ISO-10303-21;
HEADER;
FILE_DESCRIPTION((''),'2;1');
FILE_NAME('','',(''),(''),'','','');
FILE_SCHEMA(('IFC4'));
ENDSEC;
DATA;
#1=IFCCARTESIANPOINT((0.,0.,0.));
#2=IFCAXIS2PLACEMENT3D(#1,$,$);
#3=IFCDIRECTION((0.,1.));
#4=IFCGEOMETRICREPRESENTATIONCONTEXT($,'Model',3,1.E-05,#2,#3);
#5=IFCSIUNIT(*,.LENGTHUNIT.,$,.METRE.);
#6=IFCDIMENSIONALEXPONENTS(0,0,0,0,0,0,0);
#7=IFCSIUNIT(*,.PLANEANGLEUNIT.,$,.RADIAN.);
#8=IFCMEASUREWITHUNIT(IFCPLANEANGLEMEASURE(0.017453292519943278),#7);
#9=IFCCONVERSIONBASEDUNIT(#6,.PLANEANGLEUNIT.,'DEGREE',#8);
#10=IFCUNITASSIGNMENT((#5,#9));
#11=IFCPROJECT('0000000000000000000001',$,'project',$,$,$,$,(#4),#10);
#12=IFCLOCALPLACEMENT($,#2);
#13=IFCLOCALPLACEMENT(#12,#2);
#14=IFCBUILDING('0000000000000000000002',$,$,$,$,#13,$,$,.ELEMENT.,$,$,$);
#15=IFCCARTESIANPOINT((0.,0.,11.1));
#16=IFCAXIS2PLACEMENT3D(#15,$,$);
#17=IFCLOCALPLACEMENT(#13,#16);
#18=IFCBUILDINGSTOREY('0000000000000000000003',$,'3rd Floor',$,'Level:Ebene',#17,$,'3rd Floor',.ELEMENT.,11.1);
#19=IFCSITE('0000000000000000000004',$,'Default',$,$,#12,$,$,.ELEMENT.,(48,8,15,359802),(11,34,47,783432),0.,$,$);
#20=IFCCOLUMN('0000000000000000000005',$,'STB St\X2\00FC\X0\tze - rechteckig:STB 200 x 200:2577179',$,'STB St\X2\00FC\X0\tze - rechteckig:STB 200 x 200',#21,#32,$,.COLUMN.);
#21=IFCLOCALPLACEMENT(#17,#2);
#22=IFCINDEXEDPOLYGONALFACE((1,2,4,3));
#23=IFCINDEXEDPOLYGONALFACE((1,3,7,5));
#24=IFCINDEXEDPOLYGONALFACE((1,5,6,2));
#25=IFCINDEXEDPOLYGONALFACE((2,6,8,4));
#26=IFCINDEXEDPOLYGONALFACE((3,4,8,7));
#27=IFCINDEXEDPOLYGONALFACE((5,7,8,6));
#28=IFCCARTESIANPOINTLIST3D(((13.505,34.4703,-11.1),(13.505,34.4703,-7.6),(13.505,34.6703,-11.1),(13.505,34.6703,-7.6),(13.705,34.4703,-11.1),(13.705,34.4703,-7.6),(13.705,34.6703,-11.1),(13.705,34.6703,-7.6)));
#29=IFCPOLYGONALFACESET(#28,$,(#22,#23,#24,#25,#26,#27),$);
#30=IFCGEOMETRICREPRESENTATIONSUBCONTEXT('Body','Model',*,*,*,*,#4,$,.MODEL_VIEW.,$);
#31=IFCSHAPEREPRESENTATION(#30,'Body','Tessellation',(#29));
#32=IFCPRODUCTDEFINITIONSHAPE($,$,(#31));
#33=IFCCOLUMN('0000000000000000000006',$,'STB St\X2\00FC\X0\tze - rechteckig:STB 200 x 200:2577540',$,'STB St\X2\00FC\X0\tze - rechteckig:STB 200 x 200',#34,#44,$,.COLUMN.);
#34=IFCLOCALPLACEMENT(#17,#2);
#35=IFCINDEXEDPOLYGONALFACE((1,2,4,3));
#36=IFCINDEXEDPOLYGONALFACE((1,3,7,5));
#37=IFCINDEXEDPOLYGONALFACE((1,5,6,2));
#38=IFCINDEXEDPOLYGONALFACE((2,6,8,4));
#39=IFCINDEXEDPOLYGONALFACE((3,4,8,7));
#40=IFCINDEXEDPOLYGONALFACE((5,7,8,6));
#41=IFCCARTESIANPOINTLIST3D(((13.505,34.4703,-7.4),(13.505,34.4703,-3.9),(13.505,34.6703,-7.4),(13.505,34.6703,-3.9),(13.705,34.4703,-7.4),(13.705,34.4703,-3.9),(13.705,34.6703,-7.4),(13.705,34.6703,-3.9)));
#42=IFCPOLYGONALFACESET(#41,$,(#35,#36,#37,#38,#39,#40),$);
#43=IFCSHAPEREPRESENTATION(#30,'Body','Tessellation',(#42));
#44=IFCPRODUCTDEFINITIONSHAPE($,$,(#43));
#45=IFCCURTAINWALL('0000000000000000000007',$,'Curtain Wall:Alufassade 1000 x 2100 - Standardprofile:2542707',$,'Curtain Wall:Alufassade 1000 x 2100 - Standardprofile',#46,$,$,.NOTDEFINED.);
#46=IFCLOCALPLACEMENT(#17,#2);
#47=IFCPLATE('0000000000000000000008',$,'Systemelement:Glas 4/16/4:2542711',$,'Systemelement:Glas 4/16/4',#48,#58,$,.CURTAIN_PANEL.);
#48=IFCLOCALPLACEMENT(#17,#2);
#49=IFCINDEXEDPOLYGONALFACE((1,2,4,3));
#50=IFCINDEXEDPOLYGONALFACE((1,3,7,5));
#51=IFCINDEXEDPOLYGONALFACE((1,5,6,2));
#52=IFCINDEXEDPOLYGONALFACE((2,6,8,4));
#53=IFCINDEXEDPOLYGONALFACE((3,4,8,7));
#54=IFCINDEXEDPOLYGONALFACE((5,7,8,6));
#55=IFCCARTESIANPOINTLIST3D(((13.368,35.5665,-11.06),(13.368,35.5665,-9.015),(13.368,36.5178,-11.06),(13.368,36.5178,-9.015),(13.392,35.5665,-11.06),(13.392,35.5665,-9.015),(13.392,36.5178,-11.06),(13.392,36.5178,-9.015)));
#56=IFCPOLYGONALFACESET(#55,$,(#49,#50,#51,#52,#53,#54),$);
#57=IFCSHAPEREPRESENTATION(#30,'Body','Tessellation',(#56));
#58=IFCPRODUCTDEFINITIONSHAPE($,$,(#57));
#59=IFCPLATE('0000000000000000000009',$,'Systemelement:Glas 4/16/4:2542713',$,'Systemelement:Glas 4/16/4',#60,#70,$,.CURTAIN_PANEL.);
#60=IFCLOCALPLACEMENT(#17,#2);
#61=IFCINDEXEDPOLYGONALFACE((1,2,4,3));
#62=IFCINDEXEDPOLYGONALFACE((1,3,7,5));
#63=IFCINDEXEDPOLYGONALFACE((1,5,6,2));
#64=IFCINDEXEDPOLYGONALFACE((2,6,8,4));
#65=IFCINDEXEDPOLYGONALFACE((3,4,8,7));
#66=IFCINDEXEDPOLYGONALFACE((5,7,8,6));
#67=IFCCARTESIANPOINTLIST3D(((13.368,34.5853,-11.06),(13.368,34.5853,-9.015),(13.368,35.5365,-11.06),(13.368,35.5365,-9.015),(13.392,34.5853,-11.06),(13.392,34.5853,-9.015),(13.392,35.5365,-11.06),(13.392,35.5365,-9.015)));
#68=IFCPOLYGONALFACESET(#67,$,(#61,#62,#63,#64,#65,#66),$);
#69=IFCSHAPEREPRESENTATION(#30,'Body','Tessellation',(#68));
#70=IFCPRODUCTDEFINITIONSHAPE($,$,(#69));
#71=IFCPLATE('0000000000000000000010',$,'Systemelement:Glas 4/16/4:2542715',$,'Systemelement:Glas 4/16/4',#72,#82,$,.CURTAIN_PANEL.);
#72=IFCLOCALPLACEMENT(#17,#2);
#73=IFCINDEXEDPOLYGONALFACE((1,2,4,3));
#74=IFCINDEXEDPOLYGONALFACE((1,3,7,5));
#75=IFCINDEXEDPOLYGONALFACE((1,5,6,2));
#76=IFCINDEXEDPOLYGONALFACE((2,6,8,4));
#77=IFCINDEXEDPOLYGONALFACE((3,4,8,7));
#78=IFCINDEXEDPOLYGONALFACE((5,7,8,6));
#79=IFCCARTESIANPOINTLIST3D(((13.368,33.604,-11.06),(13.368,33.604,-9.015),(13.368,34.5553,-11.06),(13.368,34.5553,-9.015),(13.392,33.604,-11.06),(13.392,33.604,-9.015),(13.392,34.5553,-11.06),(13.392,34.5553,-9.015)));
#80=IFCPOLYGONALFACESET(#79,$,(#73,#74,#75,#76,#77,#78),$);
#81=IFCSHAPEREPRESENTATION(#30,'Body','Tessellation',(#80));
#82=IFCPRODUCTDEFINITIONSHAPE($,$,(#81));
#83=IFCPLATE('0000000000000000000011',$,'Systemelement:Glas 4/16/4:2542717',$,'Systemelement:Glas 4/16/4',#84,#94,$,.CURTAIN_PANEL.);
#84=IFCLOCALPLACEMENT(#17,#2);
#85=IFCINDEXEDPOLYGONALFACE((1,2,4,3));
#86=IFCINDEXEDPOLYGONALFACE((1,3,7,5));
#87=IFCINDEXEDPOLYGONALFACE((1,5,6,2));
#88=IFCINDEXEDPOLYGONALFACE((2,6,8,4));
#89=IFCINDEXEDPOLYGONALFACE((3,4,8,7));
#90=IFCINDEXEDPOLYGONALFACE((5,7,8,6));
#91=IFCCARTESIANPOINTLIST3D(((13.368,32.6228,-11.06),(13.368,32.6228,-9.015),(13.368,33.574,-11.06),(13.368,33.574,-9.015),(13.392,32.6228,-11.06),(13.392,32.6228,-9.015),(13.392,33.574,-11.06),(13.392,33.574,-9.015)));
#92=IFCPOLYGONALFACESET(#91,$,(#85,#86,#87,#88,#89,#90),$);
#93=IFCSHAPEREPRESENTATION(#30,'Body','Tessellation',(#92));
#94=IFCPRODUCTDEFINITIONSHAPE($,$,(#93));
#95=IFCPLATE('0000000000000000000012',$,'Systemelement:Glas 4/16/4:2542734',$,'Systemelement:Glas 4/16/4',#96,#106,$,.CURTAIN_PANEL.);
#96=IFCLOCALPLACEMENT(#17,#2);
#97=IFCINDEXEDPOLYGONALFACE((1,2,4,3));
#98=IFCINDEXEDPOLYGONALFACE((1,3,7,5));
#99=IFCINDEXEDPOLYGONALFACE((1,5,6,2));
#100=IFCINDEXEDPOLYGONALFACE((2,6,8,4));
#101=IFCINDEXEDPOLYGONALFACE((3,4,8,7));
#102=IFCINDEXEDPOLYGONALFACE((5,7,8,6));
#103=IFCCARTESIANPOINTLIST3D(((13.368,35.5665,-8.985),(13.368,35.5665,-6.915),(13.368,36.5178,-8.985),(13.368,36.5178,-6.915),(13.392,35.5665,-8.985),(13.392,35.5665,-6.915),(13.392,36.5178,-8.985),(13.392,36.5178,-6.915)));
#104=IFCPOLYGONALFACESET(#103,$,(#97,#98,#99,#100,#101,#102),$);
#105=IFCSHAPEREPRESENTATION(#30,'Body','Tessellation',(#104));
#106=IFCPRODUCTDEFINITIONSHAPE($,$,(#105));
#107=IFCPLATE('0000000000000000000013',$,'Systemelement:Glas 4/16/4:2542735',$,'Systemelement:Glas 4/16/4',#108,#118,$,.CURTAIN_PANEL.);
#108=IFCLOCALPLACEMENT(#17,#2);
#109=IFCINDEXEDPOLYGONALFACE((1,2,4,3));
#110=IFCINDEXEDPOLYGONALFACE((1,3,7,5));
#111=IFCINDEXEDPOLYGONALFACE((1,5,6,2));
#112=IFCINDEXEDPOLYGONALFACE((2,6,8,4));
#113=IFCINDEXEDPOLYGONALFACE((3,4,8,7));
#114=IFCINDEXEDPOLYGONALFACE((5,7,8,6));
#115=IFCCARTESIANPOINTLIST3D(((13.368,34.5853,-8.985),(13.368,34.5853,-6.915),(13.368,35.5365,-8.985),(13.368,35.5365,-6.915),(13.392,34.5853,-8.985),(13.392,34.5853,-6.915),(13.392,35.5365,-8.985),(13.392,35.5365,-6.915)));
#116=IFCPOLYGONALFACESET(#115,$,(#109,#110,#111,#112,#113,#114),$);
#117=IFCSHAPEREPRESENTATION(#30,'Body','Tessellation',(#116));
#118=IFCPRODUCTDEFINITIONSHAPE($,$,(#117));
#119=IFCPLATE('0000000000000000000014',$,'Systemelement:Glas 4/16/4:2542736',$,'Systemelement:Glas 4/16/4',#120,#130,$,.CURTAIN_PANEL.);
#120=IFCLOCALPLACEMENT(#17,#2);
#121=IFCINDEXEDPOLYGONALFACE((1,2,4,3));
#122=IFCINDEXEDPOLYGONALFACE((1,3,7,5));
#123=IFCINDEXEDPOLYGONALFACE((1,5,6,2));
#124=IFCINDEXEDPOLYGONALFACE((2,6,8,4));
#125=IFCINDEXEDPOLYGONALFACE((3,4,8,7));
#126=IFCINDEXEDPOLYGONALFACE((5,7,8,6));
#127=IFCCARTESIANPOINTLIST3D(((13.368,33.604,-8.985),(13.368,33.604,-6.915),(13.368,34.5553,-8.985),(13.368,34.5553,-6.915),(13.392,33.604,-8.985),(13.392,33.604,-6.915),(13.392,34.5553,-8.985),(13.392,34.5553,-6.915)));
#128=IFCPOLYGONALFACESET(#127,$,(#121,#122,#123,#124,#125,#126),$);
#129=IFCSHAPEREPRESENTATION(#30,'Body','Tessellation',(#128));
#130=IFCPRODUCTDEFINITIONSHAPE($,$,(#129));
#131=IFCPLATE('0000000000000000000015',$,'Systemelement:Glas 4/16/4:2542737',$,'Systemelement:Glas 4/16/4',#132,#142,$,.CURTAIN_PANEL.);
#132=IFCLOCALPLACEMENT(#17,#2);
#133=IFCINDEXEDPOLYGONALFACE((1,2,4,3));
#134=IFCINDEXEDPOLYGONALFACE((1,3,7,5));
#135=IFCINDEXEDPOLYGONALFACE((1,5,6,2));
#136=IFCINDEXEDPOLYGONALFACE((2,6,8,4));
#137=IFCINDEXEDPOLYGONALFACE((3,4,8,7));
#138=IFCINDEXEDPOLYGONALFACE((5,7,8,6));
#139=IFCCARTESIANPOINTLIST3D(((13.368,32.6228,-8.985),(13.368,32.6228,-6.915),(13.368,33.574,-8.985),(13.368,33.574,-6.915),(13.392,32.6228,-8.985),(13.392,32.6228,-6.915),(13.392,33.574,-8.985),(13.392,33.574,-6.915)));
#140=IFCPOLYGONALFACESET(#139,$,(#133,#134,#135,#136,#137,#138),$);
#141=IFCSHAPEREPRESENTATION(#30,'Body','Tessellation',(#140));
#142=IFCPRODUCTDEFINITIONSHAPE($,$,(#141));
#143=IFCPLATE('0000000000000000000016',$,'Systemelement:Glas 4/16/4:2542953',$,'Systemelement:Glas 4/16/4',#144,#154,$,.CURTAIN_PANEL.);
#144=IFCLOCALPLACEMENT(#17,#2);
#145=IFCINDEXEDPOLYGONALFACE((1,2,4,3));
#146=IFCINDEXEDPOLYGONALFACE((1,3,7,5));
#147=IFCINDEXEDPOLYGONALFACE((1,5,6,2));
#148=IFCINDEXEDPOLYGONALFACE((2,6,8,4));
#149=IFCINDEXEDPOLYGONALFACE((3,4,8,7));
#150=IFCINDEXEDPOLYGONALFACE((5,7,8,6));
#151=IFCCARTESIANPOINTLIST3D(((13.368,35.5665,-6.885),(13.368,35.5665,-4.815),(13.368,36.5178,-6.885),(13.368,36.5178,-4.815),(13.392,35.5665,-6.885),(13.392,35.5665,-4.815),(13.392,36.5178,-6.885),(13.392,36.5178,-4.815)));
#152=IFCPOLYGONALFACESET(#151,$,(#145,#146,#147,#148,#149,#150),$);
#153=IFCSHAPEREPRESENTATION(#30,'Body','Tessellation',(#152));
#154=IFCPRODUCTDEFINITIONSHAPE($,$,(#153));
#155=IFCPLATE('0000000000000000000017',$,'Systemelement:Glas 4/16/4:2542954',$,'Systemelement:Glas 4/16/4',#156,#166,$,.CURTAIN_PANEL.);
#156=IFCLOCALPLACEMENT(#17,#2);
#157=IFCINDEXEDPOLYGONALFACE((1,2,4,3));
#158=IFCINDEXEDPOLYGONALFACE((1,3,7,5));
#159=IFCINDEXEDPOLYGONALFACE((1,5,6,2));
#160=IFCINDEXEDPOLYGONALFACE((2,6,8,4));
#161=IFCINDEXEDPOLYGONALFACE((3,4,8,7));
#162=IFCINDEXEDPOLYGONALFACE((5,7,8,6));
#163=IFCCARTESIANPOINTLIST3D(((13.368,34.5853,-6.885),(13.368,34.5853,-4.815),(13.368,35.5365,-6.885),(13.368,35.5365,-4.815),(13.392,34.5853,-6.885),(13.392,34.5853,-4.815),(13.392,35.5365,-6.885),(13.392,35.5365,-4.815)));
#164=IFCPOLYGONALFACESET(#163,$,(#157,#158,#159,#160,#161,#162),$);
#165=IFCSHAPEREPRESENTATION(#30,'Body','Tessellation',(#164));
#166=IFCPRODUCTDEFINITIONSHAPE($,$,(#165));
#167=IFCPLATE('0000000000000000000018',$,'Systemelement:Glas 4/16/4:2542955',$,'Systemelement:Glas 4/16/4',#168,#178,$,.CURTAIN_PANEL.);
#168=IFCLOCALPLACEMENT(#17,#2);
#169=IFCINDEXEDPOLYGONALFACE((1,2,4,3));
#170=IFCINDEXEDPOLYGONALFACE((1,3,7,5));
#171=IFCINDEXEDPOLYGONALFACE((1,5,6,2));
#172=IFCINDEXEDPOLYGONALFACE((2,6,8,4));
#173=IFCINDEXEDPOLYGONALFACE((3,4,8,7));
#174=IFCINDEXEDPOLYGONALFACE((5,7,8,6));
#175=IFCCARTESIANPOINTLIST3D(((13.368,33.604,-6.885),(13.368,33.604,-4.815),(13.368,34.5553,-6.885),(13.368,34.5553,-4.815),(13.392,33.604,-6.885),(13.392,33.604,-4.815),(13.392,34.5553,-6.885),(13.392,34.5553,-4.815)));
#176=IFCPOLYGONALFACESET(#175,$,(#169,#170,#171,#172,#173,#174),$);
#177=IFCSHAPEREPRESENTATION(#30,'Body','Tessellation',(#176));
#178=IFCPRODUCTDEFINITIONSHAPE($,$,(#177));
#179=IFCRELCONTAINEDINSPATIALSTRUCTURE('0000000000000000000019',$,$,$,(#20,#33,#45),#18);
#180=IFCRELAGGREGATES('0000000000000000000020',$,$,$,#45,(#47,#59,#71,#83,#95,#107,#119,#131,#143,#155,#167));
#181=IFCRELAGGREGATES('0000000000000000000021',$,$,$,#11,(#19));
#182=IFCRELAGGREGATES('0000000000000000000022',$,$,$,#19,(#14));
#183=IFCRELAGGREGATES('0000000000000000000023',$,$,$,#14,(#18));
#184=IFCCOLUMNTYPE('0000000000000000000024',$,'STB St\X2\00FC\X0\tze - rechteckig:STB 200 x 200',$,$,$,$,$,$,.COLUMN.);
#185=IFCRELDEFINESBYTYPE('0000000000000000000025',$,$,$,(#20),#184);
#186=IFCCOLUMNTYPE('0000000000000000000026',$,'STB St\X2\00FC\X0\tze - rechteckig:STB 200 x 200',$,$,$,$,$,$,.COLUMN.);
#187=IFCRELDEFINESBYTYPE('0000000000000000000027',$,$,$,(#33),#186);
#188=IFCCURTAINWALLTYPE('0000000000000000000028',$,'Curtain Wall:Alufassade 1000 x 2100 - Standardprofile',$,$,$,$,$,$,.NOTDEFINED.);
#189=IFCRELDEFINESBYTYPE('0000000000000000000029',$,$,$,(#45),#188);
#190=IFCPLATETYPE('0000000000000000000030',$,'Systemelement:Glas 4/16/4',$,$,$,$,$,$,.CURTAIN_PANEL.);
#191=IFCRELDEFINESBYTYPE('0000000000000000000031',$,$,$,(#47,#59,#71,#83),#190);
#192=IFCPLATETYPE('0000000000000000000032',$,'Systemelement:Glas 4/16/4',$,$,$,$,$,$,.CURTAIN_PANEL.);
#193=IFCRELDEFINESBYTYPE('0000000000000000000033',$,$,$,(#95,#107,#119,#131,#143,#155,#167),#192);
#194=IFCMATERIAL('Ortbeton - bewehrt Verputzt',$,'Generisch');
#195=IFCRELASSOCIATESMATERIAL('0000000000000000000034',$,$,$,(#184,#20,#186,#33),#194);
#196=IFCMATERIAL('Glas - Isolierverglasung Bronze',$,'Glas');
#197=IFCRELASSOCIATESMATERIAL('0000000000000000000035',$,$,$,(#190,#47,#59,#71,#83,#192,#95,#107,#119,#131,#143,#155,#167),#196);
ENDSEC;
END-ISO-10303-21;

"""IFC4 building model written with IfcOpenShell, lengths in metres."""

from ifc_helpers import new_model, entity, si_unit, converted_unit, direction, frame, origin, place, context, subcontext, project, spatial, indexed_curve, outline, extrude, source, transform, mapped, material, type_object, type_shapes, element, aggregate, save


model = new_model("IFC4")

# Units and contexts
model_context = context("Model", 3, precision=1e-05, world=origin(), true_north=direction((0.0, 1.0)))
body_context = subcontext(model_context, "Body", "Model", "MODEL_VIEW")
ifc_project = project(units=[si_unit("LENGTHUNIT", "METRE"), converted_unit("PLANEANGLEUNIT", "DEGREE", entity("IfcPlaneAngleMeasure", 0.017453292519943278), si_unit("PLANEANGLEUNIT", "RADIAN"), dimensions=[0, 0, 0, 0, 0, 0, 0])], contexts=[model_context])

# Site, building, storey
site_placement = place(None, origin())
site = spatial("IfcSite", under=ifc_project, at=site_placement, Name="Default", CompositionType="ELEMENT", RefLatitude=(48, 8, 15, 359802), RefLongitude=(11, 34, 47, 783432), RefElevation=0.0)
building_placement = place(site_placement, origin())
building = spatial("IfcBuilding", under=site, at=building_placement, CompositionType="ELEMENT")
storey_placement = place(building_placement, frame((0.0, 0.0, 11.1)))
storey = spatial("IfcBuildingStorey", under=building, at=storey_placement, Name="3rd Floor", ObjectType="Level:Ebene", LongName="3rd Floor", CompositionType="ELEMENT", Elevation=11.1)

# Columns
ifc_material_1 = material(Name="Ortbeton - bewehrt Verputzt", Category="Generisch")
column_type_1 = type_object("IfcColumnType", Name="STB Stütze - rechteckig:STB 200 x 200", PredefinedType="COLUMN", material=ifc_material_1)
shared_shape_1 = source(origin(), body_context, "Body", "SweptSolid", [
    extrude(outline(indexed_curve([(-0.1, -0.1), (0.1, -0.1), (0.1, 0.1), (-0.1, 0.1), (-0.1, -0.1)], self_intersect=False)), frame((0.0, 0.0, 0.0), z_axis=(0.0, 0.0, 1.0), x_axis=(-1.0, 0.0, 0.0)), (0.0, 0.0, 1.0), 3.5),
])
type_shapes(column_type_1, [shared_shape_1])
column_1_placement = place(storey_placement, frame((13.605, 34.5703, -11.1)))
element("IfcColumn", 1, at=column_1_placement, inside=storey, type_object=column_type_1, material=ifc_material_1, Name="STB Stütze - rechteckig:STB 200 x 200:2577179", ObjectType="STB Stütze - rechteckig:STB 200 x 200", PredefinedType="COLUMN", context=body_context, shape_type="MappedRepresentation", body=[
    mapped(shared_shape_1, transform((0.0, 0.0, 0.0), scale=1.0)),
])
column_type_2 = type_object("IfcColumnType", Name="STB Stütze - rechteckig:STB 200 x 200", PredefinedType="COLUMN", material=ifc_material_1)
shared_shape_2 = source(origin(), body_context, "Body", "SweptSolid", [
    extrude(outline(indexed_curve([(-0.1, -0.1), (0.1, -0.1), (0.1, 0.1), (-0.1, 0.1), (-0.1, -0.1)], self_intersect=False)), frame((0.0, 0.0, 3.7), z_axis=(0.0, 0.0, 1.0), x_axis=(-1.0, 0.0, 0.0)), (0.0, 0.0, 1.0), 3.5),
])
type_shapes(column_type_2, [shared_shape_2])
column_2_placement = place(storey_placement, frame((13.605, 34.5703, -11.1)))
element("IfcColumn", 2, at=column_2_placement, inside=storey, type_object=column_type_2, material=ifc_material_1, Name="STB Stütze - rechteckig:STB 200 x 200:2577540", ObjectType="STB Stütze - rechteckig:STB 200 x 200", PredefinedType="COLUMN", context=body_context, shape_type="MappedRepresentation", body=[
    mapped(shared_shape_2, transform((0.0, 0.0, 0.0), scale=1.0)),
])

# Curtain wall, plates
curtain_wall_type = type_object("IfcCurtainWallType", Name="Curtain Wall:Alufassade 1000 x 2100 - Standardprofile", PredefinedType="NOTDEFINED")
curtain_wall_placement = place(storey_placement, frame((0.0, 0.0, -11.1)))
curtain_wall = element("IfcCurtainWall", 3, at=curtain_wall_placement, inside=storey, type_object=curtain_wall_type, Name="Curtain Wall:Alufassade 1000 x 2100 - Standardprofile:2542707", ObjectType="Curtain Wall:Alufassade 1000 x 2100 - Standardprofile", PredefinedType="NOTDEFINED")
ifc_material_2 = material(Name="Glas - Isolierverglasung Bronze", Category="Glas")
plate_type_1 = type_object("IfcPlateType", Name="Systemelement:Glas 4/16/4", PredefinedType="CURTAIN_PANEL", material=ifc_material_2)
shared_shape_3 = source(origin(), body_context, "Body", "SweptSolid", [
    extrude(outline(indexed_curve([(-0.012, -0.4756), (0.012, -0.4756), (0.012, 0.4756), (-0.012, 0.4756), (-0.012, -0.4756)], self_intersect=False)), frame((0.0, 0.0, 0.0), z_axis=(0.0, 0.0, 1.0), x_axis=(0.0, 1.0, 0.0)), (0.0, 0.0, 1.0), 2.045),
])
type_shapes(plate_type_1, [shared_shape_3])
plate_1_placement = place(curtain_wall_placement, frame((13.38, 36.0421, 0.04), z_axis=(0.0, 0.0, 1.0), x_axis=(0.0, -1.0, 0.0)))
plate_1 = element("IfcPlate", 4, at=plate_1_placement, type_object=plate_type_1, material=ifc_material_2, Name="Systemelement:Glas 4/16/4:2542711", ObjectType="Systemelement:Glas 4/16/4", PredefinedType="CURTAIN_PANEL", context=body_context, shape_type="MappedRepresentation", body=[
    mapped(shared_shape_3, transform((0.0, 0.0, 0.0), scale=1.0)),
])
plate_2_placement = place(curtain_wall_placement, frame((13.38, 35.0609, 0.04), z_axis=(0.0, 0.0, 1.0), x_axis=(0.0, -1.0, 0.0)))
plate_2 = element("IfcPlate", 5, at=plate_2_placement, type_object=plate_type_1, material=ifc_material_2, Name="Systemelement:Glas 4/16/4:2542713", ObjectType="Systemelement:Glas 4/16/4", PredefinedType="CURTAIN_PANEL", context=body_context, shape_type="MappedRepresentation", body=[
    mapped(shared_shape_3, transform((0.0, 0.0, 0.0), scale=1.0)),
])
plate_3_placement = place(curtain_wall_placement, frame((13.38, 34.0796, 0.04), z_axis=(0.0, 0.0, 1.0), x_axis=(0.0, -1.0, 0.0)))
plate_3 = element("IfcPlate", 6, at=plate_3_placement, type_object=plate_type_1, material=ifc_material_2, Name="Systemelement:Glas 4/16/4:2542715", ObjectType="Systemelement:Glas 4/16/4", PredefinedType="CURTAIN_PANEL", context=body_context, shape_type="MappedRepresentation", body=[
    mapped(shared_shape_3, transform((0.0, 0.0, 0.0), scale=1.0)),
])
plate_4_placement = place(curtain_wall_placement, frame((13.38, 33.0984, 0.04), z_axis=(0.0, 0.0, 1.0), x_axis=(0.0, -1.0, 0.0)))
plate_4 = element("IfcPlate", 7, at=plate_4_placement, type_object=plate_type_1, material=ifc_material_2, Name="Systemelement:Glas 4/16/4:2542717", ObjectType="Systemelement:Glas 4/16/4", PredefinedType="CURTAIN_PANEL", context=body_context, shape_type="MappedRepresentation", body=[
    mapped(shared_shape_3, transform((0.0, 0.0, 0.0), scale=1.0)),
])
plate_type_2 = type_object("IfcPlateType", Name="Systemelement:Glas 4/16/4", PredefinedType="CURTAIN_PANEL", material=ifc_material_2)
shared_shape_4 = source(origin(), body_context, "Body", "SweptSolid", [
    extrude(outline(indexed_curve([(-0.012, -0.4756), (0.012, -0.4756), (0.012, 0.4756), (-0.012, 0.4756), (-0.012, -0.4756)], self_intersect=False)), frame((0.0, 0.0, 0.0), z_axis=(0.0, 0.0, 1.0), x_axis=(0.0, 1.0, 0.0)), (0.0, 0.0, 1.0), 2.07),
])
type_shapes(plate_type_2, [shared_shape_4])
plate_5_placement = place(curtain_wall_placement, frame((13.38, 36.0421, 2.115), z_axis=(0.0, 0.0, 1.0), x_axis=(0.0, -1.0, 0.0)))
plate_5 = element("IfcPlate", 8, at=plate_5_placement, type_object=plate_type_2, material=ifc_material_2, Name="Systemelement:Glas 4/16/4:2542734", ObjectType="Systemelement:Glas 4/16/4", PredefinedType="CURTAIN_PANEL", context=body_context, shape_type="MappedRepresentation", body=[
    mapped(shared_shape_4, transform((0.0, 0.0, 0.0), scale=1.0)),
])
plate_6_placement = place(curtain_wall_placement, frame((13.38, 35.0609, 2.115), z_axis=(0.0, 0.0, 1.0), x_axis=(0.0, -1.0, 0.0)))
plate_6 = element("IfcPlate", 9, at=plate_6_placement, type_object=plate_type_2, material=ifc_material_2, Name="Systemelement:Glas 4/16/4:2542735", ObjectType="Systemelement:Glas 4/16/4", PredefinedType="CURTAIN_PANEL", context=body_context, shape_type="MappedRepresentation", body=[
    mapped(shared_shape_4, transform((0.0, 0.0, 0.0), scale=1.0)),
])
plate_7_placement = place(curtain_wall_placement, frame((13.38, 34.0796, 2.115), z_axis=(0.0, 0.0, 1.0), x_axis=(0.0, -1.0, 0.0)))
plate_7 = element("IfcPlate", 10, at=plate_7_placement, type_object=plate_type_2, material=ifc_material_2, Name="Systemelement:Glas 4/16/4:2542736", ObjectType="Systemelement:Glas 4/16/4", PredefinedType="CURTAIN_PANEL", context=body_context, shape_type="MappedRepresentation", body=[
    mapped(shared_shape_4, transform((0.0, 0.0, 0.0), scale=1.0)),
])
plate_8_placement = place(curtain_wall_placement, frame((13.38, 33.0984, 2.115), z_axis=(0.0, 0.0, 1.0), x_axis=(0.0, -1.0, 0.0)))
plate_8 = element("IfcPlate", 11, at=plate_8_placement, type_object=plate_type_2, material=ifc_material_2, Name="Systemelement:Glas 4/16/4:2542737", ObjectType="Systemelement:Glas 4/16/4", PredefinedType="CURTAIN_PANEL", context=body_context, shape_type="MappedRepresentation", body=[
    mapped(shared_shape_4, transform((0.0, 0.0, 0.0), scale=1.0)),
])
plate_9_placement = place(curtain_wall_placement, frame((13.38, 36.0421, 4.215), z_axis=(0.0, 0.0, 1.0), x_axis=(0.0, -1.0, 0.0)))
plate_9 = element("IfcPlate", 12, at=plate_9_placement, type_object=plate_type_2, material=ifc_material_2, Name="Systemelement:Glas 4/16/4:2542953", ObjectType="Systemelement:Glas 4/16/4", PredefinedType="CURTAIN_PANEL", context=body_context, shape_type="MappedRepresentation", body=[
    mapped(shared_shape_4, transform((0.0, 0.0, 0.0), scale=1.0)),
])
plate_10_placement = place(curtain_wall_placement, frame((13.38, 35.0609, 4.215), z_axis=(0.0, 0.0, 1.0), x_axis=(0.0, -1.0, 0.0)))
plate_10 = element("IfcPlate", 13, at=plate_10_placement, type_object=plate_type_2, material=ifc_material_2, Name="Systemelement:Glas 4/16/4:2542954", ObjectType="Systemelement:Glas 4/16/4", PredefinedType="CURTAIN_PANEL", context=body_context, shape_type="MappedRepresentation", body=[
    mapped(shared_shape_4, transform((0.0, 0.0, 0.0), scale=1.0)),
])
plate_11_placement = place(curtain_wall_placement, frame((13.38, 34.0796, 4.215), z_axis=(0.0, 0.0, 1.0), x_axis=(0.0, -1.0, 0.0)))
plate_11 = element("IfcPlate", 14, at=plate_11_placement, type_object=plate_type_2, material=ifc_material_2, Name="Systemelement:Glas 4/16/4:2542955", ObjectType="Systemelement:Glas 4/16/4", PredefinedType="CURTAIN_PANEL", context=body_context, shape_type="MappedRepresentation", body=[
    mapped(shared_shape_4, transform((0.0, 0.0, 0.0), scale=1.0)),
])
aggregate(curtain_wall, [plate_1, plate_2, plate_3, plate_4, plate_5, plate_6, plate_7, plate_8, plate_9, plate_10, plate_11])

save(model, "model.ifc")
